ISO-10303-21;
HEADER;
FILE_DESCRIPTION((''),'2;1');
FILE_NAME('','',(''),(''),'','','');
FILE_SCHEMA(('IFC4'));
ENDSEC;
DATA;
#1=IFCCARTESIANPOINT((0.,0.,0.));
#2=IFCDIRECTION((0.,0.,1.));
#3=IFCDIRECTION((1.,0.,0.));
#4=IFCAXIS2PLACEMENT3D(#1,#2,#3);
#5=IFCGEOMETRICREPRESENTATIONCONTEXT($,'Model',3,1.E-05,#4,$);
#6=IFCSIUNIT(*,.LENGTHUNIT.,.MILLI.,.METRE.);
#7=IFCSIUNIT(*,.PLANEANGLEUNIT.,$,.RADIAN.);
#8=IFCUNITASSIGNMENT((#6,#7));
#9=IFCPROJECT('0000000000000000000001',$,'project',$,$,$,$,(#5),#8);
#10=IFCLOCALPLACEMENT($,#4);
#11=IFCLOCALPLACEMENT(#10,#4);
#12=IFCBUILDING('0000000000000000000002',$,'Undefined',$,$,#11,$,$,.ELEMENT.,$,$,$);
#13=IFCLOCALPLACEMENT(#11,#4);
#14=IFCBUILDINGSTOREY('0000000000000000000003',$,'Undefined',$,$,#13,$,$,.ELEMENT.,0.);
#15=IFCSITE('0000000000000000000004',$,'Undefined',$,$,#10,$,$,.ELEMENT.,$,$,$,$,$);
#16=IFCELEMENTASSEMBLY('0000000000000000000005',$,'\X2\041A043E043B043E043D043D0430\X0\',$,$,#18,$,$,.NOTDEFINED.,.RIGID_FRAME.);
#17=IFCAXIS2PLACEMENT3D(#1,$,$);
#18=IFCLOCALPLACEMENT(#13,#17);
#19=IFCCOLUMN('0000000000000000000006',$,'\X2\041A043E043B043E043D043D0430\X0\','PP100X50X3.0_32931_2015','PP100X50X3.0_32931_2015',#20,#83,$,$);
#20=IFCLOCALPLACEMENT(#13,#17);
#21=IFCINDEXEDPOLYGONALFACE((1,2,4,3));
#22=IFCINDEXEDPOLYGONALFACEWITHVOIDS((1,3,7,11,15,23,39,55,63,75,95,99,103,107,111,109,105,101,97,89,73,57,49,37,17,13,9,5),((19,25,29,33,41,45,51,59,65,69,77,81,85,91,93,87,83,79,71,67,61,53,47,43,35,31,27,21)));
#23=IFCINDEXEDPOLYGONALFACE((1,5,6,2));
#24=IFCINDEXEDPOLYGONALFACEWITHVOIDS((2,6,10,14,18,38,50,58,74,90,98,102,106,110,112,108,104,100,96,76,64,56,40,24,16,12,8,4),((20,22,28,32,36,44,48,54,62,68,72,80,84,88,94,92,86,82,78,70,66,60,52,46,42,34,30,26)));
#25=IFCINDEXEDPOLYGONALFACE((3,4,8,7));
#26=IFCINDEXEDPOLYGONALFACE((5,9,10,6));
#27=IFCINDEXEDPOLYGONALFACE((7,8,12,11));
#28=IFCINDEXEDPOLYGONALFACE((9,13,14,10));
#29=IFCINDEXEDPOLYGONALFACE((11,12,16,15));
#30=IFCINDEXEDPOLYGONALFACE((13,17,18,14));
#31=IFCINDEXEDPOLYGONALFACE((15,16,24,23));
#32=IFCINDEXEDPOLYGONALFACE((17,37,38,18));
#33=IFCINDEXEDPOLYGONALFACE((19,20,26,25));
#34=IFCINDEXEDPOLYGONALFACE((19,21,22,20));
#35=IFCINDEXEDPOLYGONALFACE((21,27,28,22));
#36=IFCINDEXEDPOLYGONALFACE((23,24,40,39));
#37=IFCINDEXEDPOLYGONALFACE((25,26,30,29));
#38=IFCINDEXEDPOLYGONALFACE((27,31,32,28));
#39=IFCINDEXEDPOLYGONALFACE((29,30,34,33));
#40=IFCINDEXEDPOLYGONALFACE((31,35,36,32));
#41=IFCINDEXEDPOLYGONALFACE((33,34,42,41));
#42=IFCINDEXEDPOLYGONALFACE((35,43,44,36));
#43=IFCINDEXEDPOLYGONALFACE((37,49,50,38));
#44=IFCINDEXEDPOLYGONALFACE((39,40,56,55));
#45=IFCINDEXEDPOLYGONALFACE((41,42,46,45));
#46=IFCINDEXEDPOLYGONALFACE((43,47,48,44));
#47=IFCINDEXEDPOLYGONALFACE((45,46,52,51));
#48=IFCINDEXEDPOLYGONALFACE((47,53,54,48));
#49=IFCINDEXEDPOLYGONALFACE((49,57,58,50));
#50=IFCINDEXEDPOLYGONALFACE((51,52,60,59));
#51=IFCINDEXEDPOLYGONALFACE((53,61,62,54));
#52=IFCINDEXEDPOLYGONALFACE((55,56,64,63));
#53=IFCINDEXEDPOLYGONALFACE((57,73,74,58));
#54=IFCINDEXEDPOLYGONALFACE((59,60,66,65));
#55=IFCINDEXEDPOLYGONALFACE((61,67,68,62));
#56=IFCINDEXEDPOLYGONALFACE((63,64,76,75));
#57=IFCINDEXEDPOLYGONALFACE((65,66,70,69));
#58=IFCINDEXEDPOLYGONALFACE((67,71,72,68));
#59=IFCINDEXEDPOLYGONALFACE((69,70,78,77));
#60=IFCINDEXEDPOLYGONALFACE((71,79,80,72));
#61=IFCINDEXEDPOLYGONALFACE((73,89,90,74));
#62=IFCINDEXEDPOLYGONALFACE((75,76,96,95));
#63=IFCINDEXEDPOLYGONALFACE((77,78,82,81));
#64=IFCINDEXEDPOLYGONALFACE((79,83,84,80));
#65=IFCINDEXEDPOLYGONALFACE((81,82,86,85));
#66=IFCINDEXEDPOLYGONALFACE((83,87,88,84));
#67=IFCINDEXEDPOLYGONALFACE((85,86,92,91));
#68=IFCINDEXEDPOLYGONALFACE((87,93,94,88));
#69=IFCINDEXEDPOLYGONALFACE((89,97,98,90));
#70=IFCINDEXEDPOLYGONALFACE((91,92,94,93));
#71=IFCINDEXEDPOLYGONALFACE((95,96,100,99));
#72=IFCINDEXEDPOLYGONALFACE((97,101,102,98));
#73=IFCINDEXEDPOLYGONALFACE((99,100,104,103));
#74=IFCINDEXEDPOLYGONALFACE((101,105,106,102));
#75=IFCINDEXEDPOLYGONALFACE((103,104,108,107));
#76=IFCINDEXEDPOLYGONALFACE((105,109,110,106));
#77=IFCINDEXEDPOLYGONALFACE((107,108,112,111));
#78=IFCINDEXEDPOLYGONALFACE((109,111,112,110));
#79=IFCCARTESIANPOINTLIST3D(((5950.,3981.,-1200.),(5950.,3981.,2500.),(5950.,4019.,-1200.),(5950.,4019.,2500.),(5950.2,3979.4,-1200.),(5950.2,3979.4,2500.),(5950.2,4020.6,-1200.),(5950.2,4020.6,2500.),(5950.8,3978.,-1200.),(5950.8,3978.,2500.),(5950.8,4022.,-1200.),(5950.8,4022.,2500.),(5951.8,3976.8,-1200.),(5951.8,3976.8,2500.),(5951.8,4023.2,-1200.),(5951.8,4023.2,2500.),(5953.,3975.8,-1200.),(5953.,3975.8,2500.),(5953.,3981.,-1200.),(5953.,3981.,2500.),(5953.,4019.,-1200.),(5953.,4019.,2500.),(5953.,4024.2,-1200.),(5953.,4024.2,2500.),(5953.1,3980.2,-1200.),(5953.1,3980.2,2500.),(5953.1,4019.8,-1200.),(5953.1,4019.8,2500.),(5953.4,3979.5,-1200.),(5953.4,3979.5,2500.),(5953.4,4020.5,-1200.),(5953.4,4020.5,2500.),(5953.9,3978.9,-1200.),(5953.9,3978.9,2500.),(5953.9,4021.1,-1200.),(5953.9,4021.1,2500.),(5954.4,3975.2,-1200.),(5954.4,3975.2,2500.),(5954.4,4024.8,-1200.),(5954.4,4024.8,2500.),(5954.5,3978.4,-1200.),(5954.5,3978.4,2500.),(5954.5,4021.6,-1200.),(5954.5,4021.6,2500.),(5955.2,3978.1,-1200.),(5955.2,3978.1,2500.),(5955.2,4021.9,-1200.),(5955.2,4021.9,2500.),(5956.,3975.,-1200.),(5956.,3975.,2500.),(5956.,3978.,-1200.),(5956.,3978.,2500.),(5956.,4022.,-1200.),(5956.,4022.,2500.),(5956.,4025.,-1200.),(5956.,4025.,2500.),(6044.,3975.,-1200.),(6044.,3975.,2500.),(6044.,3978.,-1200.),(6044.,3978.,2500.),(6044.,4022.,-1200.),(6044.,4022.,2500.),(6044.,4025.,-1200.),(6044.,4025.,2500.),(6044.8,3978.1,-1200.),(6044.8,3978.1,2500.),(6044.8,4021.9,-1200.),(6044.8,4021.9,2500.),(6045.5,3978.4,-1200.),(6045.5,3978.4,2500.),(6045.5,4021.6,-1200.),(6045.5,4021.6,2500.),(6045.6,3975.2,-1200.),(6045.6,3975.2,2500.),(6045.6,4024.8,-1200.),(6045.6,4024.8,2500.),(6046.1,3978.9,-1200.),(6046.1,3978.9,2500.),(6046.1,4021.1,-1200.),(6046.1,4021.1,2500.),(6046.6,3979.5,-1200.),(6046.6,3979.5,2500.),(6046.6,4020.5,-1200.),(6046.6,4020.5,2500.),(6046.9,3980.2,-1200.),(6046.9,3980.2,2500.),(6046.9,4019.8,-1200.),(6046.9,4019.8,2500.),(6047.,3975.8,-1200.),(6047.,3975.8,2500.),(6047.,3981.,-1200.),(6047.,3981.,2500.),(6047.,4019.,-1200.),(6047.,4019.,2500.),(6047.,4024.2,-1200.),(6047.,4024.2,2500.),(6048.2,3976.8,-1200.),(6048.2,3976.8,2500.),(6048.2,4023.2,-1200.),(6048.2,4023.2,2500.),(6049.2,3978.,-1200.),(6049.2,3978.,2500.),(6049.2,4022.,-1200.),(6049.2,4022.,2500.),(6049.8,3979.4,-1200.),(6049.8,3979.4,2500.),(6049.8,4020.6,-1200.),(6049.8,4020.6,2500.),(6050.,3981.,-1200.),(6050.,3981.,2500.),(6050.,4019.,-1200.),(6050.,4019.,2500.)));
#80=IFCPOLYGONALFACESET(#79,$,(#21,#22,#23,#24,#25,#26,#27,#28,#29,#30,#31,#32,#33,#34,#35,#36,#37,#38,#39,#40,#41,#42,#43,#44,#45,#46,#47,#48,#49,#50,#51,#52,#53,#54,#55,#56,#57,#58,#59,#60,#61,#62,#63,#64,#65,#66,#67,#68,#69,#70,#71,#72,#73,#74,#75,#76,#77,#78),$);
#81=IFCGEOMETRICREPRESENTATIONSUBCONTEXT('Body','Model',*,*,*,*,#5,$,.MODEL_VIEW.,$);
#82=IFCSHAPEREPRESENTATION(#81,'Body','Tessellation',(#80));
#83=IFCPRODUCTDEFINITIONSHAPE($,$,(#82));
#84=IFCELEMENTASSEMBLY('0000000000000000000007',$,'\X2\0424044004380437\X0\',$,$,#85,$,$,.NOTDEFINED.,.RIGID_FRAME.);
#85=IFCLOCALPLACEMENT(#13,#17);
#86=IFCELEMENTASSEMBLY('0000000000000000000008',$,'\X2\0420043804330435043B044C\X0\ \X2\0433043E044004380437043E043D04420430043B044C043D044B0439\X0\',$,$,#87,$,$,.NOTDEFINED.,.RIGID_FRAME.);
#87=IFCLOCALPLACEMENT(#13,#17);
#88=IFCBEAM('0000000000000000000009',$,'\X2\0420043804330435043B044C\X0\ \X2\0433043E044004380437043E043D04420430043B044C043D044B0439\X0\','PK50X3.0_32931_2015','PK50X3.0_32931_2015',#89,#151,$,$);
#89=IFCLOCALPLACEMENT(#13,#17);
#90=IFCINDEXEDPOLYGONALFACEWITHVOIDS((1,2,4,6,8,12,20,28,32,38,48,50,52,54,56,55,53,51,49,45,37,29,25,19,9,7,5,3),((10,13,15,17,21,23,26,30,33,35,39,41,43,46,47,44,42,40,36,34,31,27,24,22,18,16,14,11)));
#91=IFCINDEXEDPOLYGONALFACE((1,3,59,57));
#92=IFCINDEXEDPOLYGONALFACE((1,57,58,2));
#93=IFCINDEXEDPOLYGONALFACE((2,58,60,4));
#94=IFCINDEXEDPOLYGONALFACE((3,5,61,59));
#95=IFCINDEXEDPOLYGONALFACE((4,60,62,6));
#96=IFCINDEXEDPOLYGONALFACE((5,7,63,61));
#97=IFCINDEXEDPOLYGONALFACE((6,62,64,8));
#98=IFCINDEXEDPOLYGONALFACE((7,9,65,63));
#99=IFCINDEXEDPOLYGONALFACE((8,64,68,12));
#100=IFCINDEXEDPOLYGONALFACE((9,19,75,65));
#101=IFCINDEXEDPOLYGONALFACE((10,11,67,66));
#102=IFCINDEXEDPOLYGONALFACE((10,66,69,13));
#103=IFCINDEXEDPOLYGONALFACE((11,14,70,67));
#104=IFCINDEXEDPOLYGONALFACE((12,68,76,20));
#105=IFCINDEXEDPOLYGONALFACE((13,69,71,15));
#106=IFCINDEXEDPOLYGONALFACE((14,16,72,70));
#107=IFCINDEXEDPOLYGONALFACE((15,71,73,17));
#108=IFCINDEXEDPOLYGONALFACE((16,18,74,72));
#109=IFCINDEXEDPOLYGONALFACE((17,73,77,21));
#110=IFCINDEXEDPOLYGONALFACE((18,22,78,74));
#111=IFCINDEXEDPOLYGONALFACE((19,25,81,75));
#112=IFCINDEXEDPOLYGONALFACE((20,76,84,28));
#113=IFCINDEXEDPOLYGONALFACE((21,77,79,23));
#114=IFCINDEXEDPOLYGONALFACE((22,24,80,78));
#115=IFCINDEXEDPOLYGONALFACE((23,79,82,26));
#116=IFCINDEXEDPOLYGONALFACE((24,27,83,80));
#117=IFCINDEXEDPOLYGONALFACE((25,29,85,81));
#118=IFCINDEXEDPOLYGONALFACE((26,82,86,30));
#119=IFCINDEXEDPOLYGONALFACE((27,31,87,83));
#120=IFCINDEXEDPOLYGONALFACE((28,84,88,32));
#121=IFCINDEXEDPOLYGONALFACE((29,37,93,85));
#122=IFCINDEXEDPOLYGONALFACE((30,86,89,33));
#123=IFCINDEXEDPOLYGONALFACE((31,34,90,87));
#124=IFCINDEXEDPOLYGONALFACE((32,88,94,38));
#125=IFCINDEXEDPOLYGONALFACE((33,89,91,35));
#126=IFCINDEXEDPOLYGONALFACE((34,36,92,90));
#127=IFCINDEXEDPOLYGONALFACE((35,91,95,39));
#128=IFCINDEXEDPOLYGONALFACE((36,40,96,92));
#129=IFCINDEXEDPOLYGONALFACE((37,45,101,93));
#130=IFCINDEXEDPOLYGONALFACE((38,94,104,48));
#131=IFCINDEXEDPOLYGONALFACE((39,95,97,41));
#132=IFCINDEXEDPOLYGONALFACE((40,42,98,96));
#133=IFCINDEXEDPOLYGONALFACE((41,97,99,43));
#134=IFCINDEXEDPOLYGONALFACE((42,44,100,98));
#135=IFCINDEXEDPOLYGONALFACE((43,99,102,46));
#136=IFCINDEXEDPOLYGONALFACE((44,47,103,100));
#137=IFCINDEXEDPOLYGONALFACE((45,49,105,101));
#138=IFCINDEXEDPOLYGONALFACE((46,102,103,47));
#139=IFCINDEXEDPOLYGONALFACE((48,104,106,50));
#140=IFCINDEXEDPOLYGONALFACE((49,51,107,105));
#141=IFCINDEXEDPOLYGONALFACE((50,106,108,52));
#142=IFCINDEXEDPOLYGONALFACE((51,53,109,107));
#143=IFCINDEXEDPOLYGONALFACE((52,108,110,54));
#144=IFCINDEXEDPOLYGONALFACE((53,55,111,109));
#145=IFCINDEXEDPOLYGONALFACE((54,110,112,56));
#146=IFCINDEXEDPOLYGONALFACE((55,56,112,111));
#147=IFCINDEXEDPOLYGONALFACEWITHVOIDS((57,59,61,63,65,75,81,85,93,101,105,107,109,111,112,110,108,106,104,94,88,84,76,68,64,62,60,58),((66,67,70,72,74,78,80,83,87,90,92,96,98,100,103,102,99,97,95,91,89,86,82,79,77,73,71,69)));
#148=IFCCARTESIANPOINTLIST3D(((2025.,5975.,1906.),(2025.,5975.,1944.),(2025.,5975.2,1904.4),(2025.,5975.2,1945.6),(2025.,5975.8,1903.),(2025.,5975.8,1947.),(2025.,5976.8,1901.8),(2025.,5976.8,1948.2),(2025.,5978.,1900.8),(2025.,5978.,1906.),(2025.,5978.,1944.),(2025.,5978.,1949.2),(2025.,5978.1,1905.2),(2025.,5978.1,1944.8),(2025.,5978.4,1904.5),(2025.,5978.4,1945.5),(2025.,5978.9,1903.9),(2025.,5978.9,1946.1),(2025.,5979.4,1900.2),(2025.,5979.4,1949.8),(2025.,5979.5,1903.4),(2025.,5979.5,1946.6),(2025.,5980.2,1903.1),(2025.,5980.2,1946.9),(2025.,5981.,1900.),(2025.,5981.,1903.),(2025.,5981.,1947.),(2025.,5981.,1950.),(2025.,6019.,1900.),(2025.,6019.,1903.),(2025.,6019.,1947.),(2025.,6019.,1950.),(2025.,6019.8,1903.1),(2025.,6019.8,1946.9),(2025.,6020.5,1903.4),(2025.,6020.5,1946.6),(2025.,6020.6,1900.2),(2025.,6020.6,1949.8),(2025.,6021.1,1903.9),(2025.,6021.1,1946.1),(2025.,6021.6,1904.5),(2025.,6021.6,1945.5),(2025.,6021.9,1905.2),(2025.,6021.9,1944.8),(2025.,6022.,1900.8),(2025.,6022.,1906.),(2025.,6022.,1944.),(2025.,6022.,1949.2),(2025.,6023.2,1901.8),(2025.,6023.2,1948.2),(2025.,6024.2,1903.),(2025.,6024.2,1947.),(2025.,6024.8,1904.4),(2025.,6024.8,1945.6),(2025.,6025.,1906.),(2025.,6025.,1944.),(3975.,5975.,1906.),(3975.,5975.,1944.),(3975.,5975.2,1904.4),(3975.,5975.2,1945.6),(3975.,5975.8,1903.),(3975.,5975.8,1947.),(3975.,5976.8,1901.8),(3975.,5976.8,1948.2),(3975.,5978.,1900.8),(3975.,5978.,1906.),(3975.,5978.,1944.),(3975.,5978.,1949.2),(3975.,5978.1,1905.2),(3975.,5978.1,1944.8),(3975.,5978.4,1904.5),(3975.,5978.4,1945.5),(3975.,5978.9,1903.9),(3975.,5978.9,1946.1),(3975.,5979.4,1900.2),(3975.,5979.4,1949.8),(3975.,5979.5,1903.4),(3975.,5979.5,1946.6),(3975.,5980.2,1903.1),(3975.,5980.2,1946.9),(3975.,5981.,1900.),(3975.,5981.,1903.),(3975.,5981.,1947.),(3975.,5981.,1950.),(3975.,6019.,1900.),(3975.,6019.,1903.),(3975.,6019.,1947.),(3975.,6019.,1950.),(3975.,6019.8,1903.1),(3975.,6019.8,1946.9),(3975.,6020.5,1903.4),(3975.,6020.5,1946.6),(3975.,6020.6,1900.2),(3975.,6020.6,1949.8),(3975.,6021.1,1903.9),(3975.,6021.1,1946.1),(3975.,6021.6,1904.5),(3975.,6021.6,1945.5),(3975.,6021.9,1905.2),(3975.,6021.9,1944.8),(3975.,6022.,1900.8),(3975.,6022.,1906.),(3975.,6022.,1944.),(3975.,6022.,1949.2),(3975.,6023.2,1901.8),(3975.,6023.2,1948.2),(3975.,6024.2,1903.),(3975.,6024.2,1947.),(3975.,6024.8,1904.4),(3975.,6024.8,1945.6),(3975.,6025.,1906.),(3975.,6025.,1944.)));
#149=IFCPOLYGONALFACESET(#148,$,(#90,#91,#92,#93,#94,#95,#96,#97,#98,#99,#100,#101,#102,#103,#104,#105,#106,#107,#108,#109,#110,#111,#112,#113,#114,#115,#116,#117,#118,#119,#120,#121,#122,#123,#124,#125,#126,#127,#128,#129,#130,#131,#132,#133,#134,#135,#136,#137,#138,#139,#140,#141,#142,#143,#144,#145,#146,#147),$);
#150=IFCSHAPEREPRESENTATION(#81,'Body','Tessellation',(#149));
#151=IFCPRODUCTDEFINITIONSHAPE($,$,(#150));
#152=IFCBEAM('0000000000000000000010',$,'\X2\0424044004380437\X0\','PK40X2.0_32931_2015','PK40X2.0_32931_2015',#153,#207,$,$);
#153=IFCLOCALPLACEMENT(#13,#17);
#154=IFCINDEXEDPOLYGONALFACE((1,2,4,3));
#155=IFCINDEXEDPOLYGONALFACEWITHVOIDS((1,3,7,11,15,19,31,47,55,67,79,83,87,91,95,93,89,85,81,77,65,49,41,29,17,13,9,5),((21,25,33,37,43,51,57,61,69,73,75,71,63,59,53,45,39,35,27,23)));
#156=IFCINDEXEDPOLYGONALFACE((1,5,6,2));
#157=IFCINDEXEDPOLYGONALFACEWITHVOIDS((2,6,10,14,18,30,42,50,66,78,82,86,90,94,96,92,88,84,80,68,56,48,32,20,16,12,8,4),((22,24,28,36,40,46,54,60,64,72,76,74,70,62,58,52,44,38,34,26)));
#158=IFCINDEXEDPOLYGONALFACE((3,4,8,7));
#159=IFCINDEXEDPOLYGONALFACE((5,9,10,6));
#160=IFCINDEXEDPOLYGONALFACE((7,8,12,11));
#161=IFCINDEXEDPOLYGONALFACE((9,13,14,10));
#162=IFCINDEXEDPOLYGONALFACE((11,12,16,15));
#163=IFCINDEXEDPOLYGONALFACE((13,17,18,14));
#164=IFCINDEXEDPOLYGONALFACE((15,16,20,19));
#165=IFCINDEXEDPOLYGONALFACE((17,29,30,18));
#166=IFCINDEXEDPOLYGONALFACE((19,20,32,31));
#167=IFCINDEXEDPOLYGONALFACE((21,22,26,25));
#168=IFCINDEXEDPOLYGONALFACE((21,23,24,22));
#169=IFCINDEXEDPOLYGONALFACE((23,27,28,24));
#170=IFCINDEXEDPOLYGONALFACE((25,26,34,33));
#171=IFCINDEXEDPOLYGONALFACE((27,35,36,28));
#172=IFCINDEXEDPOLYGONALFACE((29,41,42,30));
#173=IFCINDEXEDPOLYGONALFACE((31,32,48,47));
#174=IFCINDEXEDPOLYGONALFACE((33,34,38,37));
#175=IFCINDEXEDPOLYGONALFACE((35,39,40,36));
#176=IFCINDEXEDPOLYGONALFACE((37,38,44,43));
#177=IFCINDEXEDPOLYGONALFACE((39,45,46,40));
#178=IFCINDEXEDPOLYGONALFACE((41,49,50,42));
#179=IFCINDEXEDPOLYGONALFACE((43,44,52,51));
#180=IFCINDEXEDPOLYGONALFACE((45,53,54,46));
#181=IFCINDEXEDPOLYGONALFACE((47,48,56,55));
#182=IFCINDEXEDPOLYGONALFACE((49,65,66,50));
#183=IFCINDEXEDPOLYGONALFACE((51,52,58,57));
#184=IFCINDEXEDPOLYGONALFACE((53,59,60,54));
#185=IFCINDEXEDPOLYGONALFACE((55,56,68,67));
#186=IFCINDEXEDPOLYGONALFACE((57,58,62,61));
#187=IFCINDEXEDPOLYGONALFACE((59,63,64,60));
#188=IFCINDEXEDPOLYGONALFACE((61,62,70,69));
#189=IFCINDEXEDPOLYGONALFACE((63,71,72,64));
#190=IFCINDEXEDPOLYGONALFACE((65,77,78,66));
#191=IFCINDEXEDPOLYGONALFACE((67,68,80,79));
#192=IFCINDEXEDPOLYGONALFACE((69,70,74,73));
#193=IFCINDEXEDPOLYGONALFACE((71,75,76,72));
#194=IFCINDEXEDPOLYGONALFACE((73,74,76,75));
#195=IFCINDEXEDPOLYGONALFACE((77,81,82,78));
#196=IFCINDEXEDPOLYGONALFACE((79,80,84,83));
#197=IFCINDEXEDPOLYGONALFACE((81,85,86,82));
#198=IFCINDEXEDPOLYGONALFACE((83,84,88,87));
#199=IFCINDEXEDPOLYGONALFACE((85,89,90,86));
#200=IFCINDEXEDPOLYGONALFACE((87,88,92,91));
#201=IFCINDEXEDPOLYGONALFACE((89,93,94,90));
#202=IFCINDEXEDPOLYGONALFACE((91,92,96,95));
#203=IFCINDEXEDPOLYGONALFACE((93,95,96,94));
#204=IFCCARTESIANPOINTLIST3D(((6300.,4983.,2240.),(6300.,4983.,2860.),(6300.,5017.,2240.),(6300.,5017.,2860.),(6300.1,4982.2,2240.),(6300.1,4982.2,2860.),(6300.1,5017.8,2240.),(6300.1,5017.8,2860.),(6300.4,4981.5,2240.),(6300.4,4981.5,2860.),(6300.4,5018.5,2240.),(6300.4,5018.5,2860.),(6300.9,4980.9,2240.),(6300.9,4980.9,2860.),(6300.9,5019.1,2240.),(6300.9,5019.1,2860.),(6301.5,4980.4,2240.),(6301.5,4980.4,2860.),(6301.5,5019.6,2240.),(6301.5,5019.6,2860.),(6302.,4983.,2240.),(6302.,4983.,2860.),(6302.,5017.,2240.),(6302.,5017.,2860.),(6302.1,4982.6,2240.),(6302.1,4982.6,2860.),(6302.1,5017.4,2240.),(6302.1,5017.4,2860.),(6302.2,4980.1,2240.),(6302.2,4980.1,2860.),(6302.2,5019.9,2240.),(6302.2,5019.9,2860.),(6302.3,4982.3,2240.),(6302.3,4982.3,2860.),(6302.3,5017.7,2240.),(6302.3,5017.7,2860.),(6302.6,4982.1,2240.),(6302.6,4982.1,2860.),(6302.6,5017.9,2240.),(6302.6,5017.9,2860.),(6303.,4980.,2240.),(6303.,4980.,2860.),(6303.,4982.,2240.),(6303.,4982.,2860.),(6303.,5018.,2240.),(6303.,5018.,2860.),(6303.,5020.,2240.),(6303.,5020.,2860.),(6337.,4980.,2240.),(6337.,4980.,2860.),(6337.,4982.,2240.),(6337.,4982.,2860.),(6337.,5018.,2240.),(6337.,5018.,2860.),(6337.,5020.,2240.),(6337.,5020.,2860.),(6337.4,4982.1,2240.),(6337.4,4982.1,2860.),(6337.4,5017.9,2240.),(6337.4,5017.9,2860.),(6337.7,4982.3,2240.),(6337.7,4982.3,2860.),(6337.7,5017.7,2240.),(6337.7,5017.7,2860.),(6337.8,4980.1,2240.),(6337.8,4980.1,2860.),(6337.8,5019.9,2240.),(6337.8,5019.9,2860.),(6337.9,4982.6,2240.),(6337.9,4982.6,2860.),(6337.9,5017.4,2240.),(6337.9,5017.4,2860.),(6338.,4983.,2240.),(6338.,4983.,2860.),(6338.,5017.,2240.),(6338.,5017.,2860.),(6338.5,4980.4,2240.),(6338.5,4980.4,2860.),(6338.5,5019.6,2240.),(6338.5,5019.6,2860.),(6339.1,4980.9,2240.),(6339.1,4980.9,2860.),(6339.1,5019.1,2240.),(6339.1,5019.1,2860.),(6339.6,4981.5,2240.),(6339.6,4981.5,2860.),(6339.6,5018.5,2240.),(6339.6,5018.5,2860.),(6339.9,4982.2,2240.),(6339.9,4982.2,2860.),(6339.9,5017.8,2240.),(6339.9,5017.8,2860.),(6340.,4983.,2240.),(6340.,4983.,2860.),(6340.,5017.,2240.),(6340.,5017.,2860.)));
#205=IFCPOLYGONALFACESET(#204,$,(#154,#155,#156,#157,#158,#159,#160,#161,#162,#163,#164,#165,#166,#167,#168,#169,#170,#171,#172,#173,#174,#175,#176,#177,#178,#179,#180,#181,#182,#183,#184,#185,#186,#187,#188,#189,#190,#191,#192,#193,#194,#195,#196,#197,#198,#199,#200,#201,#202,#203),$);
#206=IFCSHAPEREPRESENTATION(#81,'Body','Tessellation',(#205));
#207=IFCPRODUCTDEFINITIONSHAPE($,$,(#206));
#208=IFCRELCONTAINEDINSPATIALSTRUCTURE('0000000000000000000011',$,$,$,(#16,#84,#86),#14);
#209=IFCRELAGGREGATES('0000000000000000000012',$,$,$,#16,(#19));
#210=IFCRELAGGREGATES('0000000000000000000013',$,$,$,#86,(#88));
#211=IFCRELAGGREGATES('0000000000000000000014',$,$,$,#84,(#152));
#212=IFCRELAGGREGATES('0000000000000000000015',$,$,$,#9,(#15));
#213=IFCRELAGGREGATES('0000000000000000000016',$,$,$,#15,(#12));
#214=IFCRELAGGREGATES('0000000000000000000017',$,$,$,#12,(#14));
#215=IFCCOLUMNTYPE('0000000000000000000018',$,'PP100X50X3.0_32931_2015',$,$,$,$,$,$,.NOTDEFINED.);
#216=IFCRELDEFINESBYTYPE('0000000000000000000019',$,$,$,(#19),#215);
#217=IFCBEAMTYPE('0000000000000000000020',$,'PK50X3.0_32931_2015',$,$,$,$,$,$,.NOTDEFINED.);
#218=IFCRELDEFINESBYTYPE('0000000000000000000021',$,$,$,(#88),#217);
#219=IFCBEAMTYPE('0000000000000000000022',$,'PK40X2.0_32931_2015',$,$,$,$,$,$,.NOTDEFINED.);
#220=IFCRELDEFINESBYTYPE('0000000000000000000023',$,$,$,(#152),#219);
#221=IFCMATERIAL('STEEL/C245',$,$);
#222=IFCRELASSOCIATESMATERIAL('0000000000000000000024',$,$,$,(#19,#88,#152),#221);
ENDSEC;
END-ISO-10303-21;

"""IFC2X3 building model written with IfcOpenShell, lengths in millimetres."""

from ifc_helpers import new_model, si_unit, frame, origin_with_axes, origin_2d_with_axis, place, context, subcontext, project, spatial, hollow_rectangle, extrude, material, type_object, element, aggregate, save


model = new_model("IFC2X3")

# Units and contexts
model_context = context("Model", 3, precision=1e-05, world=origin_with_axes())
body_context = subcontext(model_context, "Body", "Model", "MODEL_VIEW")
ifc_project = project(units=[si_unit("LENGTHUNIT", "METRE", prefix="MILLI"), si_unit("PLANEANGLEUNIT", "RADIAN")], contexts=[model_context])

# Site, building, storey
site_placement = place(None, origin_with_axes())
site = spatial("IfcSite", under=ifc_project, at=site_placement, Name="Undefined", CompositionType="ELEMENT")
building_placement = place(site_placement, origin_with_axes())
building = spatial("IfcBuilding", under=site, at=building_placement, Name="Undefined", CompositionType="ELEMENT")
storey_placement = place(building_placement, origin_with_axes())
storey = spatial("IfcBuildingStorey", under=building, at=storey_placement, Name="Undefined", CompositionType="ELEMENT", Elevation=0.0)

# Element assembly, column
ifc_material_1 = material(Name="STEEL/C245")
assembly_1_placement = place(storey_placement, origin_with_axes())
assembly_1 = element("IfcElementAssembly", 1, at=assembly_1_placement, inside=storey, Name="Колонна", AssemblyPlace="NOTDEFINED", PredefinedType="RIGID_FRAME")
column_type_1 = type_object("IfcColumnType", Name="PP100X50X3.0_32931_2015", PredefinedType="NOTDEFINED")
column_1_placement = place(assembly_1_placement, frame((6000.0, 4000.0, -1200.0), z_axis=(0.0, 0.0, 1.0), x_axis=(-1.0, 0.0, 0.0)))
column_1 = element("IfcColumn", 2, at=column_1_placement, type_object=column_type_1, material=ifc_material_1, Name="Колонна", Description="PP100X50X3.0_32931_2015", ObjectType="PP100X50X3.0_32931_2015", context=body_context, shape_type="SweptSolid", body=[
    extrude(hollow_rectangle(XDim=50.0, YDim=100.0, WallThickness=3.0, InnerFilletRadius=3.0, OuterFilletRadius=6.0, at=origin_2d_with_axis()), frame((0.0, 0.0, 3700.0), z_axis=(0.0, 0.0, -1.0), x_axis=(0.0, 1.0, 0.0)), (0.0, 0.0, 1.0), 3700.0),
])
aggregate(assembly_1, [column_1])

# Element assembly
assembly_2_placement = place(storey_placement, origin_with_axes())
assembly_2 = element("IfcElementAssembly", 3, at=assembly_2_placement, inside=storey, Name="Фриз", AssemblyPlace="NOTDEFINED", PredefinedType="RIGID_FRAME")

# Element assembly, beam
assembly_3_placement = place(storey_placement, origin_with_axes())
assembly_3 = element("IfcElementAssembly", 4, at=assembly_3_placement, inside=storey, Name="Ригель горизонтальный", AssemblyPlace="NOTDEFINED", PredefinedType="RIGID_FRAME")
beam_type_1 = type_object("IfcBeamType", Name="PK50X3.0_32931_2015", PredefinedType="NOTDEFINED")
beam_1_placement = place(assembly_3_placement, frame((3975.0, 6000.0, 1925.0), z_axis=(0.0, 0.0, 1.0), x_axis=(-1.0, 0.0, 0.0)))
beam_1 = element("IfcBeam", 5, at=beam_1_placement, type_object=beam_type_1, material=ifc_material_1, Name="Ригель горизонтальный", Description="PK50X3.0_32931_2015", ObjectType="PK50X3.0_32931_2015", context=body_context, shape_type="SweptSolid", body=[
    extrude(hollow_rectangle(XDim=50.0, YDim=50.0, WallThickness=3.0, InnerFilletRadius=3.0, OuterFilletRadius=6.0, at=origin_2d_with_axis()), frame((1950.0, 0.0, 0.0), z_axis=(-1.0, 0.0, 0.0), x_axis=(0.0, -1.0, 0.0)), (0.0, 0.0, 1.0), 1950.0),
])
aggregate(assembly_3, [beam_1])

# Beam
beam_type_2 = type_object("IfcBeamType", Name="PK40X2.0_32931_2015", PredefinedType="NOTDEFINED")
beam_2_placement = place(assembly_2_placement, frame((6320.0, 5000.0, 2860.0), z_axis=(-1.0, 0.0, 0.0), x_axis=(0.0, 0.0, -1.0)))
beam_2 = element("IfcBeam", 6, at=beam_2_placement, type_object=beam_type_2, material=ifc_material_1, Name="Фриз", Description="PK40X2.0_32931_2015", ObjectType="PK40X2.0_32931_2015", context=body_context, shape_type="SweptSolid", body=[
    extrude(hollow_rectangle(XDim=40.0, YDim=40.0, WallThickness=2.0, InnerFilletRadius=1.0, OuterFilletRadius=3.0, at=origin_2d_with_axis()), frame((620.0, 0.0, 0.0), z_axis=(-1.0, 0.0, 0.0), x_axis=(0.0, -1.0, 0.0)), (0.0, 0.0, 1.0), 620.0),
])
aggregate(assembly_2, [beam_2])

save(model, "model.ifc")
